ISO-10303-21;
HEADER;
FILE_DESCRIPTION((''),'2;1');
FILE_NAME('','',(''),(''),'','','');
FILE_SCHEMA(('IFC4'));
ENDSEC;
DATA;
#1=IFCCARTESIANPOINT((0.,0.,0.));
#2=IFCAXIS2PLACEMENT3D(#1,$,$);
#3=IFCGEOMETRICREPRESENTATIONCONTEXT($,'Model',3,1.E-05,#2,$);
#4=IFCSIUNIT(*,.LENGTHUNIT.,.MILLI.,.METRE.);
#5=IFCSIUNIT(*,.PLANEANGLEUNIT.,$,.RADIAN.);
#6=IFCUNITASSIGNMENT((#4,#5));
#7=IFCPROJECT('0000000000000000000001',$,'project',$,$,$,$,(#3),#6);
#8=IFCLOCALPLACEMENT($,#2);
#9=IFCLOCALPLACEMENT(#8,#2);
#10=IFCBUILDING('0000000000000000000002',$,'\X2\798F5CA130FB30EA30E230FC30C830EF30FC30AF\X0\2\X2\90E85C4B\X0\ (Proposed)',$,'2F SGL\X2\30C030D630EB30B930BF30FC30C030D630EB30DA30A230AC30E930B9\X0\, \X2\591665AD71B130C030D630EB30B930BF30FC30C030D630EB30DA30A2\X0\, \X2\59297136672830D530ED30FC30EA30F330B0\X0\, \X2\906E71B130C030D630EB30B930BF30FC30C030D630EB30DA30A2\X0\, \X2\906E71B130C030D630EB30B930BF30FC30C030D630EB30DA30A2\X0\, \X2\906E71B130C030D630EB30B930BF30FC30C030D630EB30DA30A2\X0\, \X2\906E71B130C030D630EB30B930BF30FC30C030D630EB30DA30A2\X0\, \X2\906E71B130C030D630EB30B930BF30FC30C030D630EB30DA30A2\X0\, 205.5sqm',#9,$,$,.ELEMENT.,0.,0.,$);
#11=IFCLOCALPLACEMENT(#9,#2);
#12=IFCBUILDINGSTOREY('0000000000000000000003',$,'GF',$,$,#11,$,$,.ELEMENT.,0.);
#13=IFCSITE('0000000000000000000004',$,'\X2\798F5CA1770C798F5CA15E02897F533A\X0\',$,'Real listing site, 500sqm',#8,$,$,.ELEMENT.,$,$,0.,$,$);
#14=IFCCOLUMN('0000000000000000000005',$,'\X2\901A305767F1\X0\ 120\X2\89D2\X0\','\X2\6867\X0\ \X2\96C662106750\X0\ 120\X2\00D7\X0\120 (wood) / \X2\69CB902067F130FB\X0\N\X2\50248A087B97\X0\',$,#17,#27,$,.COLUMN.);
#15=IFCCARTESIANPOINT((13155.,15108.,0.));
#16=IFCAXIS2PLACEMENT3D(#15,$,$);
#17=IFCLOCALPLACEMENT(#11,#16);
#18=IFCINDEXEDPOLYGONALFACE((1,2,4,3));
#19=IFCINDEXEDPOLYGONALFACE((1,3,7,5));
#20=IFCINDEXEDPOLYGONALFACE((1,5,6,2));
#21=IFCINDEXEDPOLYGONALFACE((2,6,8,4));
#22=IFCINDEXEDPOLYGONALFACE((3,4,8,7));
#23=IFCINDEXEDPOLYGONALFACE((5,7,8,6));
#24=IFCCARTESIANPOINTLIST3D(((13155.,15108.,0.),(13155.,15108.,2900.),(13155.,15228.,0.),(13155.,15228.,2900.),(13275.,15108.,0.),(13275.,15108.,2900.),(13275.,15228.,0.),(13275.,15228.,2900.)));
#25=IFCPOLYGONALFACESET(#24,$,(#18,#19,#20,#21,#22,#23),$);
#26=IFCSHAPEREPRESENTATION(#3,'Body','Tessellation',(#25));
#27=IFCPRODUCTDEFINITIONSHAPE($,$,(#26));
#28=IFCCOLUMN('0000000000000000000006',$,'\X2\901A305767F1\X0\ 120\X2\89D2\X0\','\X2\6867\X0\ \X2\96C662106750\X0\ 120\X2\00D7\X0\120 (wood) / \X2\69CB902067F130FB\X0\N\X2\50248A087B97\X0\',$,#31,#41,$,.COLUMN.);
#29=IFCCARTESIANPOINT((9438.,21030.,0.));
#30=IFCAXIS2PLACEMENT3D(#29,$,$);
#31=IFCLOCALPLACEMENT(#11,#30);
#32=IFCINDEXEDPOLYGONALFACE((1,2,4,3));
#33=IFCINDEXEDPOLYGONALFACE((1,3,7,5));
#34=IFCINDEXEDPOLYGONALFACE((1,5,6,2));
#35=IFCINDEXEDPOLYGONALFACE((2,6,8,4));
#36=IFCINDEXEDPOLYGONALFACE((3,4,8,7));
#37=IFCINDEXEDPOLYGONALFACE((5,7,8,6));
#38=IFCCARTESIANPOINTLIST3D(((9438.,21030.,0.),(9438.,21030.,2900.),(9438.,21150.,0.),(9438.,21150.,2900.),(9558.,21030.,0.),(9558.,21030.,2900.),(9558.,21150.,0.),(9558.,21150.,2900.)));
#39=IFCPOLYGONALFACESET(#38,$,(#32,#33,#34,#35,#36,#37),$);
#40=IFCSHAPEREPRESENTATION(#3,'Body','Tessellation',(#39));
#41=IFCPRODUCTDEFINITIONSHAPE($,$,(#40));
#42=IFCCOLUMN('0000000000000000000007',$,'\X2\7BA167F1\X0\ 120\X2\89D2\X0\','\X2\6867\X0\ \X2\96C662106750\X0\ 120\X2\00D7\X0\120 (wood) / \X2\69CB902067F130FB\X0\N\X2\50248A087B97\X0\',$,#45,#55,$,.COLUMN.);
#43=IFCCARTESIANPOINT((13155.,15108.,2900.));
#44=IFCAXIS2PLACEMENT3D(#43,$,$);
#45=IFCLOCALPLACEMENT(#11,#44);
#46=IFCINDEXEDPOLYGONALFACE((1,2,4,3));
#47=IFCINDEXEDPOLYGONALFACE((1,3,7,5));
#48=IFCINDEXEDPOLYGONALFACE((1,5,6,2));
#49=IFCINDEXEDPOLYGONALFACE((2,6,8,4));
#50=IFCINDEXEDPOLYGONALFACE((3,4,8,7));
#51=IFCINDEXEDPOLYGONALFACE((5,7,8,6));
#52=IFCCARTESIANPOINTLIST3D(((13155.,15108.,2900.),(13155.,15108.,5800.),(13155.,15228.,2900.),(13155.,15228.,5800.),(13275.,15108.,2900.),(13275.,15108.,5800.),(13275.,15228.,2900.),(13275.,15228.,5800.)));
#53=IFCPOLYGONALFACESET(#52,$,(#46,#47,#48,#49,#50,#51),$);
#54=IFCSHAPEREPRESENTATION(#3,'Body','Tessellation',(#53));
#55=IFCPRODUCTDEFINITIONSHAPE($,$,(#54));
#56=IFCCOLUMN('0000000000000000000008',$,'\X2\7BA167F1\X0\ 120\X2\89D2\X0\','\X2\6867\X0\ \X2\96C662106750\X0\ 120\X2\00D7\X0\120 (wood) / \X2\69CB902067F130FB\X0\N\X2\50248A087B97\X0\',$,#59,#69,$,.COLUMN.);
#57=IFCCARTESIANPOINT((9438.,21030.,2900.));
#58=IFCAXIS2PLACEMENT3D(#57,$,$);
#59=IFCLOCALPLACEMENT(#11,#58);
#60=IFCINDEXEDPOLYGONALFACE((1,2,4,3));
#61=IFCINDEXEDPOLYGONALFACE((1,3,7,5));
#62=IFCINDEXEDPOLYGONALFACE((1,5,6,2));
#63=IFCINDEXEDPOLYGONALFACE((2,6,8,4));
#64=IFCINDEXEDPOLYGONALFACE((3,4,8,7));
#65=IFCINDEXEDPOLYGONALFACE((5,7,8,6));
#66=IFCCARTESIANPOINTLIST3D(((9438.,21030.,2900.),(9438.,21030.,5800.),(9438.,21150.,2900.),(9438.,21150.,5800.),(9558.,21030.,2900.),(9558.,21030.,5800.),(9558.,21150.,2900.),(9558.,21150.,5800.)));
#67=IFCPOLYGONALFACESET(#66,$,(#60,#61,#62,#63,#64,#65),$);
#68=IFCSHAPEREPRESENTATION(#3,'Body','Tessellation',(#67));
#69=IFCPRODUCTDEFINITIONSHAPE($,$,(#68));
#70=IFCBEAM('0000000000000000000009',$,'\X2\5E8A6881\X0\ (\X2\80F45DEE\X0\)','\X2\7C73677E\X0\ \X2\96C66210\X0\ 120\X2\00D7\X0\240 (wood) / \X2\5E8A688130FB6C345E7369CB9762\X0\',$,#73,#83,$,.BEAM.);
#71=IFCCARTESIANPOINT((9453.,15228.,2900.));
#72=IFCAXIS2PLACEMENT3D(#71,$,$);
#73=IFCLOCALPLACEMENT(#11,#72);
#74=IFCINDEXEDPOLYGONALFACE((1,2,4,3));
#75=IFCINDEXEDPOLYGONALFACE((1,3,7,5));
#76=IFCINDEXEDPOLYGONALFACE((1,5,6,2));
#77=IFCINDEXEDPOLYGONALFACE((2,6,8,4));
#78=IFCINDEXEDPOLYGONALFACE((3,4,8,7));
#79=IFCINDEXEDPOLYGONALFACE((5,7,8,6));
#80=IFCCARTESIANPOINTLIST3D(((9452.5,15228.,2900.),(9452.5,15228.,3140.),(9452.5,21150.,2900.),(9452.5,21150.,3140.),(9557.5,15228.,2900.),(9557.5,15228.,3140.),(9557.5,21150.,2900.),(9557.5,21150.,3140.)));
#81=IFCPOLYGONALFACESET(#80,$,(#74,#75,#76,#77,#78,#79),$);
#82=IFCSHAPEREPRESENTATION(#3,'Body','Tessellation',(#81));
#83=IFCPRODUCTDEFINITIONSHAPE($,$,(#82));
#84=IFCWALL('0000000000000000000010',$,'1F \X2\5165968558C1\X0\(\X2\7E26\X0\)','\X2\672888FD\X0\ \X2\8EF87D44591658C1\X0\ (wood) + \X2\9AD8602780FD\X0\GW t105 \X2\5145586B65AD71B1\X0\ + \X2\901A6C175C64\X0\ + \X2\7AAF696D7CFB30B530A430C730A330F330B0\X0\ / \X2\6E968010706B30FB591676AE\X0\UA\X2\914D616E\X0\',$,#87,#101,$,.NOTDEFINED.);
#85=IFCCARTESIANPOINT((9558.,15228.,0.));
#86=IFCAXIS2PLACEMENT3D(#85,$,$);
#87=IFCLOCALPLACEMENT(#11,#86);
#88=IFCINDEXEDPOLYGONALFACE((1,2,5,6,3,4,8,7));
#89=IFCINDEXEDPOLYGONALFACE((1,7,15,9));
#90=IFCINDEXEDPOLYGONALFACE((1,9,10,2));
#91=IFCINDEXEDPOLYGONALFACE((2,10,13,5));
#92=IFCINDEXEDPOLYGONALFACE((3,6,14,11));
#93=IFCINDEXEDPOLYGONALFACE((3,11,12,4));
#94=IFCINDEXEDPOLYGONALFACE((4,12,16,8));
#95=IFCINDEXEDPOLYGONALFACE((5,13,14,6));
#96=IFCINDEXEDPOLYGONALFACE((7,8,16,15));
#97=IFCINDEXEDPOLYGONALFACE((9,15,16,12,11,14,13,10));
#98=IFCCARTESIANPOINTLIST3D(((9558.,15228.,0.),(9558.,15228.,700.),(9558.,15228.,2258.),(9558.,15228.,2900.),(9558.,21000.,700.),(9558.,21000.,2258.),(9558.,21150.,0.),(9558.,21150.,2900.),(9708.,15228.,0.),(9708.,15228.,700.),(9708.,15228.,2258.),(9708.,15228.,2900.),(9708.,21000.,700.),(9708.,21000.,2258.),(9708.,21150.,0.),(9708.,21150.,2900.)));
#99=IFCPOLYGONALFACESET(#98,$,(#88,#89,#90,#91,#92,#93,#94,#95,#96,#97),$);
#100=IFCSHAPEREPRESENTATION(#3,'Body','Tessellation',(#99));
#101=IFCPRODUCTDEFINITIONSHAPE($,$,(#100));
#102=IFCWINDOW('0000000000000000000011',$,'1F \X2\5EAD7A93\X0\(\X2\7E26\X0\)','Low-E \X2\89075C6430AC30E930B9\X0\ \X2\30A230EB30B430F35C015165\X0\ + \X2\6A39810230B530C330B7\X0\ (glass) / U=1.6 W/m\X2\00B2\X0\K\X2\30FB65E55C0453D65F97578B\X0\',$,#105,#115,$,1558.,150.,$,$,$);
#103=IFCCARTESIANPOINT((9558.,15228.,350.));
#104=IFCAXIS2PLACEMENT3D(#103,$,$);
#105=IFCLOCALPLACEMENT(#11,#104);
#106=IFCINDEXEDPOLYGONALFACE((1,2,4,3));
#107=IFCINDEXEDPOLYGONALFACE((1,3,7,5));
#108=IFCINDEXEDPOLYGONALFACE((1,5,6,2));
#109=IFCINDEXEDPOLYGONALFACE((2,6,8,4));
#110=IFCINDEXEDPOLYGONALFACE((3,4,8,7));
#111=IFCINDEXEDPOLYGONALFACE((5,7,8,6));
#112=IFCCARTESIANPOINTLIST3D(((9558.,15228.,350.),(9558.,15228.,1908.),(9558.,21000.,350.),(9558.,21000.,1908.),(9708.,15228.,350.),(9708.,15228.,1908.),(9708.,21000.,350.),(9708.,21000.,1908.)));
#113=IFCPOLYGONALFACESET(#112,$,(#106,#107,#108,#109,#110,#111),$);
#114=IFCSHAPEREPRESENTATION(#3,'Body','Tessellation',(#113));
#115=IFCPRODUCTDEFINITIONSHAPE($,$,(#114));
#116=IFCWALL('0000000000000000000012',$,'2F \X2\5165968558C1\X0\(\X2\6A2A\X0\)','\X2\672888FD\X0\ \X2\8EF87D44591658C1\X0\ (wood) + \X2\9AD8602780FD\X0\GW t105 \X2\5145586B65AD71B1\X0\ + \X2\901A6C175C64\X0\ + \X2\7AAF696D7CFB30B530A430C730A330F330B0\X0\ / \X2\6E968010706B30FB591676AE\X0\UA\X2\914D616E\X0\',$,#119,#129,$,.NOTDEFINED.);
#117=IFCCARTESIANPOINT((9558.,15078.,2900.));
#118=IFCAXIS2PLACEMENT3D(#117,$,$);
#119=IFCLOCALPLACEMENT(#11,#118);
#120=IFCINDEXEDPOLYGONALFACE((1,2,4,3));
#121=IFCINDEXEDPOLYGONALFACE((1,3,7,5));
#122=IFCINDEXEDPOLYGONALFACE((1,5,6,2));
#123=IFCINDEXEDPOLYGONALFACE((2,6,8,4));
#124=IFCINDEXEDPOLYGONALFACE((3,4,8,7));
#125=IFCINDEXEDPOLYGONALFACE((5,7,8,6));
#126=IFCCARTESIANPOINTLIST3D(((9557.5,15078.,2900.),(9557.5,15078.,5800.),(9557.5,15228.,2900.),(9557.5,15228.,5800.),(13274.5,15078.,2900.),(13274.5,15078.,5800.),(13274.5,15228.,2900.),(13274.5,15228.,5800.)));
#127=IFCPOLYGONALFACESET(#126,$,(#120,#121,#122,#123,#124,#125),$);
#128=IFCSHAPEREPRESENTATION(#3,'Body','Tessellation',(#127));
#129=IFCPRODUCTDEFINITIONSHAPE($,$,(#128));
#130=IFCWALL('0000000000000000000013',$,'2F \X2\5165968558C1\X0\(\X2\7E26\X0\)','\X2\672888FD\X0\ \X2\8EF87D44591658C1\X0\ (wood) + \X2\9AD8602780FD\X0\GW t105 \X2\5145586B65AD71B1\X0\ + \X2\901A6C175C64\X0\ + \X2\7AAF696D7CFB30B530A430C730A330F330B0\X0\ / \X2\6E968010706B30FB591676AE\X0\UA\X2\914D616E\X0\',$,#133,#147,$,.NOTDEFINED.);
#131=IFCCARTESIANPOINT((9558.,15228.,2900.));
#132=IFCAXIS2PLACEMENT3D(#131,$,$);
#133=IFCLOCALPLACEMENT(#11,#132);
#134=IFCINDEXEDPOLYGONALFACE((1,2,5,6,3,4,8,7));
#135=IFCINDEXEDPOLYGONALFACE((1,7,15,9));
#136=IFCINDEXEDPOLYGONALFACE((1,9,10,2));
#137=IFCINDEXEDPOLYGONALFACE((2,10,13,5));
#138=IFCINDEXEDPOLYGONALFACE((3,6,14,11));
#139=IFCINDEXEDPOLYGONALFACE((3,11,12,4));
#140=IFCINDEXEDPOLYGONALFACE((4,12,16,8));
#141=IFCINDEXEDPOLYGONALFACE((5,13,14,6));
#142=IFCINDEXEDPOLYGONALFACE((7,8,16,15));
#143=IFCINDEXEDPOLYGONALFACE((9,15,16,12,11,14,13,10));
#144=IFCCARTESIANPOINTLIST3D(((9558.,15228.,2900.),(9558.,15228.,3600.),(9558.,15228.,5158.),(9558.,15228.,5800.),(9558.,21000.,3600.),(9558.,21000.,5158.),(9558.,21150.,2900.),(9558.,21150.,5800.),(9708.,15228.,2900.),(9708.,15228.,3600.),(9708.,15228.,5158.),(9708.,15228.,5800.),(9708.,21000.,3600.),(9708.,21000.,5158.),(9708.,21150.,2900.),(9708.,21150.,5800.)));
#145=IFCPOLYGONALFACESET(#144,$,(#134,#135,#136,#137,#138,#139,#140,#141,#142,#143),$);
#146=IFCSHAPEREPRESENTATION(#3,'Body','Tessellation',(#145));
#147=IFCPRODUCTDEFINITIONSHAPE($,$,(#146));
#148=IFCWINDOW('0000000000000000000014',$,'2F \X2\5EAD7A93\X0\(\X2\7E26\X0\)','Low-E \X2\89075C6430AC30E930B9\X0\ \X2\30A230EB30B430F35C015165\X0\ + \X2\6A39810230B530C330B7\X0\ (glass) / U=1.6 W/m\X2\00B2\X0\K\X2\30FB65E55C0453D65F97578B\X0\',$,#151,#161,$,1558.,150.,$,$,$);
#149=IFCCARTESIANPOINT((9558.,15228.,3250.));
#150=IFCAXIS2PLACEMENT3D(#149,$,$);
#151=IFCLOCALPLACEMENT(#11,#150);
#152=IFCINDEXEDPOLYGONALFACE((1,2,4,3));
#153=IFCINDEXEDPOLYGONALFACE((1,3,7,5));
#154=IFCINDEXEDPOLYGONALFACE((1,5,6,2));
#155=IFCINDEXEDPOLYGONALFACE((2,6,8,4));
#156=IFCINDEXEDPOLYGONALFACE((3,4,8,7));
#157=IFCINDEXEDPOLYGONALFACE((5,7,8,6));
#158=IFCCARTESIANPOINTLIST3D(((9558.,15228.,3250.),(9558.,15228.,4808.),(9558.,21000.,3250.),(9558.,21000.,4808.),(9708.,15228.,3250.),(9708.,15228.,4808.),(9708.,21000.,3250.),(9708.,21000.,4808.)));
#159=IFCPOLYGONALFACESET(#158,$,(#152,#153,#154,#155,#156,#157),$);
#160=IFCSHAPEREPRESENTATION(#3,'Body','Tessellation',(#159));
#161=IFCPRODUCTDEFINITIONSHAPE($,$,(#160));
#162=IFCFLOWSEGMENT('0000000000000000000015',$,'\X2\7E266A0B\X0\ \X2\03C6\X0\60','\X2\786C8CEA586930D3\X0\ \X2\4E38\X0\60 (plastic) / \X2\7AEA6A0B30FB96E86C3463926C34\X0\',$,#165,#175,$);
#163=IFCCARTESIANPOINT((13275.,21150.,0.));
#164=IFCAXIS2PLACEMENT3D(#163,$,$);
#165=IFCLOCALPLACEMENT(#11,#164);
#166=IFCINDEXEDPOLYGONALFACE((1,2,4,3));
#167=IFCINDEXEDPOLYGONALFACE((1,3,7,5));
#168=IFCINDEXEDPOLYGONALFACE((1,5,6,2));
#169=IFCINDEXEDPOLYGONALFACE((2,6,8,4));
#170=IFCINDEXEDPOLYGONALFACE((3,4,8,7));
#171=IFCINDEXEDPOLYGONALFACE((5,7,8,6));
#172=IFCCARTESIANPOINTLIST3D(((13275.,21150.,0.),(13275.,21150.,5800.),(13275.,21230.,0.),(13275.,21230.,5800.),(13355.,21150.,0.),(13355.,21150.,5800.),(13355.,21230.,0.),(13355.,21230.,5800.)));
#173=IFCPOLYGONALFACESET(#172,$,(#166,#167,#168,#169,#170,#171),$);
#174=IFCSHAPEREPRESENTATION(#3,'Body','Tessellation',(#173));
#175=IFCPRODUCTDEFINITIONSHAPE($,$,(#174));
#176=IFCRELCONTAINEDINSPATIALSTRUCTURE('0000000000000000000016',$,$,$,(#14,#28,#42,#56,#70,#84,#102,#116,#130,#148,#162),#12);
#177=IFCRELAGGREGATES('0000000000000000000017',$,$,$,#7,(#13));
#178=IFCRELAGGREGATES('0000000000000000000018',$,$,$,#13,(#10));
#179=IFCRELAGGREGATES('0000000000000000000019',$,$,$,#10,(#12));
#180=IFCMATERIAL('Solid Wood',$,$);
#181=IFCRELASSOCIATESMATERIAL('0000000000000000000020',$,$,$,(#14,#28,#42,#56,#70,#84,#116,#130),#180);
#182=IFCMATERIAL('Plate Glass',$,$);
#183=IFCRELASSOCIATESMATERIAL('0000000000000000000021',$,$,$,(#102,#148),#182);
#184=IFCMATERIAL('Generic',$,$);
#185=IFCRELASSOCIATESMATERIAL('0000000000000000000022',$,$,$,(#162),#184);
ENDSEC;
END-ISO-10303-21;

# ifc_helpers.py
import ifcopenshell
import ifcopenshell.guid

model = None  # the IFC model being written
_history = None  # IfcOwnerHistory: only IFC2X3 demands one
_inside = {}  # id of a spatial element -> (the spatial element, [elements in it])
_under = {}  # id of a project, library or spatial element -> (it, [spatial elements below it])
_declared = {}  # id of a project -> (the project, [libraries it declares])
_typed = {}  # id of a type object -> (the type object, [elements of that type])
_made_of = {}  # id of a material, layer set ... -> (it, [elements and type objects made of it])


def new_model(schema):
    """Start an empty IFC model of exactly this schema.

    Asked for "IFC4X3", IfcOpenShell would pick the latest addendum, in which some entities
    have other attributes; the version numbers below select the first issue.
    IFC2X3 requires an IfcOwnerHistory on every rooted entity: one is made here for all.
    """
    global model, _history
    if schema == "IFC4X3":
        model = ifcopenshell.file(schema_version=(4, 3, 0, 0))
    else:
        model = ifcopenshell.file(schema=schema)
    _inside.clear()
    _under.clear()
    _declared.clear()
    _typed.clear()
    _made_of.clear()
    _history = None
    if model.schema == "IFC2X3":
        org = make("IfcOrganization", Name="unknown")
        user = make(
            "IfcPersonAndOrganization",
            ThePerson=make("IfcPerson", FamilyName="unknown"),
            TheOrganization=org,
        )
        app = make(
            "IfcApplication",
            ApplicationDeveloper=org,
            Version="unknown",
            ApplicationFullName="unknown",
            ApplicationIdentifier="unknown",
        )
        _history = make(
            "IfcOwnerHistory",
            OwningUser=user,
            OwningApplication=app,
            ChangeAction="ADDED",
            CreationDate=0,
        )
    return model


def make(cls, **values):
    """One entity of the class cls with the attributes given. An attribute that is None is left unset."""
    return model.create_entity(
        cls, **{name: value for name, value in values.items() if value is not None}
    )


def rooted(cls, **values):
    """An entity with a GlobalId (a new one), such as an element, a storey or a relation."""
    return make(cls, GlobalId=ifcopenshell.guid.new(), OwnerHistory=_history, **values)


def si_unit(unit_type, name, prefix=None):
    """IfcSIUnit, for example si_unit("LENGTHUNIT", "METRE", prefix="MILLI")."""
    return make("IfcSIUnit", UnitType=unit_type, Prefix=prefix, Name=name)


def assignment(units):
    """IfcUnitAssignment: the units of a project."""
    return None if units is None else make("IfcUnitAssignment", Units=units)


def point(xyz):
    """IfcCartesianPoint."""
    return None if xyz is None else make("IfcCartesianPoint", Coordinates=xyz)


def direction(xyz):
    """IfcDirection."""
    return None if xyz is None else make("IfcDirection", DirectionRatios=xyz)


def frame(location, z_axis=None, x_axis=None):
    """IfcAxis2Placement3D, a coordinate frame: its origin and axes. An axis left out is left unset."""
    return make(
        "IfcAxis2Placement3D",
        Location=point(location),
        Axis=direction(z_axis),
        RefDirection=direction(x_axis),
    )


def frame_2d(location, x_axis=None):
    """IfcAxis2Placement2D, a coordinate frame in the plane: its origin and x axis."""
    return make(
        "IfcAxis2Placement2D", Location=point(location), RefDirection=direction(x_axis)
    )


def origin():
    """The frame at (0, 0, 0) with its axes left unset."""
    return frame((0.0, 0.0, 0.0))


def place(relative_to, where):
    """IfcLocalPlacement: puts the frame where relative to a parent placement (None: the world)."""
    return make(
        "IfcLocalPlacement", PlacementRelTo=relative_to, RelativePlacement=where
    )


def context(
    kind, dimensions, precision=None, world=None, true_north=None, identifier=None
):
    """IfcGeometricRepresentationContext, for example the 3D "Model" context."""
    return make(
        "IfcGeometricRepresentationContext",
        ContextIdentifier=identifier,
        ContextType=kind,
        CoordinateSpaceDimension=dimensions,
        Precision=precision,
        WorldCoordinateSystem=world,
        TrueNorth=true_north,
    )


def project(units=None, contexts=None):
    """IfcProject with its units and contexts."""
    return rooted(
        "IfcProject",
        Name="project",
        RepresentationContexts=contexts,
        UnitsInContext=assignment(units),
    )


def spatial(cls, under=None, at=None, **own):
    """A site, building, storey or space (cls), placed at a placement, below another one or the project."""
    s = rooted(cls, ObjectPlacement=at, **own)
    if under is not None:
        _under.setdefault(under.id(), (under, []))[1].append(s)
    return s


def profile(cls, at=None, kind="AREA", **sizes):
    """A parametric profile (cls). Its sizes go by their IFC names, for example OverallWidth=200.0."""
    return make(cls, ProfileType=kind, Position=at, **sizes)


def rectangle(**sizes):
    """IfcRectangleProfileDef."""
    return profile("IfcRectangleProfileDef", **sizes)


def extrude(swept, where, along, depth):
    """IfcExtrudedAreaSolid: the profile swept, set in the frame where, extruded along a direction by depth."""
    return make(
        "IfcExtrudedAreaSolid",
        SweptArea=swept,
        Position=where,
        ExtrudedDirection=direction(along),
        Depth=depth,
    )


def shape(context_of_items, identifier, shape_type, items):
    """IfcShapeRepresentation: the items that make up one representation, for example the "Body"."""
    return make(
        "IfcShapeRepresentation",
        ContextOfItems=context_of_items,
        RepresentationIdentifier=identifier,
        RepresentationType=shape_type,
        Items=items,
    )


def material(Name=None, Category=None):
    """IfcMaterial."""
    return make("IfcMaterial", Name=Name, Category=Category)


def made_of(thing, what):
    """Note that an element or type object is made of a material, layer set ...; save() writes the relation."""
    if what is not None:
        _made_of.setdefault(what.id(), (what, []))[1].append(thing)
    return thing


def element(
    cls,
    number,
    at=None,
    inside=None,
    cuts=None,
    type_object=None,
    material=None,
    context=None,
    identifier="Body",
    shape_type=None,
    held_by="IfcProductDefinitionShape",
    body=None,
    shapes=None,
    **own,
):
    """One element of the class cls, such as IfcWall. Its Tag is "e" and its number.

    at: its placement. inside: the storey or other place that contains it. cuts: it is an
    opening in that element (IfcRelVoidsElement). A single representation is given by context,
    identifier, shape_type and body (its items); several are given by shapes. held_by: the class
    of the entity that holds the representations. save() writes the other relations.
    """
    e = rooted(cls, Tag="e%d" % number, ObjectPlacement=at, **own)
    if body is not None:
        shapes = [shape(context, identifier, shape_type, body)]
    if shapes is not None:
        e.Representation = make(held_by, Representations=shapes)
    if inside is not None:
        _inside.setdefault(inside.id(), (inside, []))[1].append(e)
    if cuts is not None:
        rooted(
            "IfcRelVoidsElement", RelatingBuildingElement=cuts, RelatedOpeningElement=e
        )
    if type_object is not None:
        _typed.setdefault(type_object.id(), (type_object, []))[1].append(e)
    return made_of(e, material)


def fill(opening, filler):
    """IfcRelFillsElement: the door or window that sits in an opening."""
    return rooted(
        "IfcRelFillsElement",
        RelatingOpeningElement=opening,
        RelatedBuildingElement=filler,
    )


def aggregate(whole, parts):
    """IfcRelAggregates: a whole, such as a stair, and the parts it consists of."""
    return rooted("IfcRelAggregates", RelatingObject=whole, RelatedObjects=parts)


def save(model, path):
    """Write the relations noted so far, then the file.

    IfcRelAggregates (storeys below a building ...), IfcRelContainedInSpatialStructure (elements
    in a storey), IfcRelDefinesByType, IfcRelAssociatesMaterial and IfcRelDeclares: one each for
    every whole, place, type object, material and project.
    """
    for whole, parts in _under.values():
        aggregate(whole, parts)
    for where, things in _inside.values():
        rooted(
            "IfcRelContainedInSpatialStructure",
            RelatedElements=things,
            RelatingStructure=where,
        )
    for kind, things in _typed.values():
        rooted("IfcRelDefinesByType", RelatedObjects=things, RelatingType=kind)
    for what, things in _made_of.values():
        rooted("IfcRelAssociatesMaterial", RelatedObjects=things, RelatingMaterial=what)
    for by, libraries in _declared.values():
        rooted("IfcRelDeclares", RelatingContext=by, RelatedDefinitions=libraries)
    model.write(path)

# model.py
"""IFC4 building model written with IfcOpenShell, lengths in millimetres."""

from ifc_helpers import new_model, si_unit, frame, frame_2d, origin, place, context, project, spatial, rectangle, extrude, material, element, fill, save


model = new_model("IFC4")

# Units and contexts
model_context = context("Model", 3, precision=1e-05, world=origin())
ifc_project = project(units=[si_unit("LENGTHUNIT", "METRE", prefix="MILLI"), si_unit("PLANEANGLEUNIT", "RADIAN")], contexts=[model_context])

# Site, building, storey
site_placement = place(None, origin())
site = spatial("IfcSite", under=ifc_project, at=site_placement, Name="福岡県福岡市西区", ObjectType="Real listing site, 500sqm", CompositionType="ELEMENT", RefElevation=0.0)
building_placement = place(site_placement, origin())
building = spatial("IfcBuilding", under=site, at=building_placement, Name="福岡・リモートワーク2部屋 (Proposed)", ObjectType="2F SGLダブルスターダブルペアガラス, 外断熱ダブルスターダブルペア, 天然木フローリング, 遮熱ダブルスターダブルペア, 遮熱ダブルスターダブルペア, 遮熱ダブルスターダブルペア, 遮熱ダブルスターダブルペア, 遮熱ダブルスターダブルペア, 205.5sqm", CompositionType="ELEMENT", ElevationOfRefHeight=0.0, ElevationOfTerrain=0.0)
storey_placement = place(building_placement, origin())
storey = spatial("IfcBuildingStorey", under=building, at=storey_placement, Name="GF", CompositionType="ELEMENT", Elevation=0.0)

# Columns
ifc_material_1 = material(Name="Solid Wood")
column_1_placement = place(storey_placement, frame((13155.0, 15108.0, 0.0)))
element("IfcColumn", 1, at=column_1_placement, inside=storey, material=ifc_material_1, Name="通し柱 120角", Description="桧 集成材 120×120 (wood) / 構造柱・N値計算", PredefinedType="COLUMN", context=model_context, shape_type="SweptSolid", body=[
    extrude(rectangle(XDim=120.0, YDim=120.0, at=frame_2d((60.0, 60.0))), frame((13155.0, 15108.0, 0.0)), (0.0, 0.0, 1.0), 2900.0),
])
column_2_placement = place(storey_placement, frame((9438.0, 21030.0, 0.0)))
element("IfcColumn", 2, at=column_2_placement, inside=storey, material=ifc_material_1, Name="通し柱 120角", Description="桧 集成材 120×120 (wood) / 構造柱・N値計算", PredefinedType="COLUMN", context=model_context, shape_type="SweptSolid", body=[
    extrude(rectangle(XDim=120.0, YDim=120.0, at=frame_2d((60.0, 60.0))), frame((9438.0, 21030.0, 0.0)), (0.0, 0.0, 1.0), 2900.0),
])
column_3_placement = place(storey_placement, frame((13155.0, 15108.0, 2900.0)))
element("IfcColumn", 3, at=column_3_placement, inside=storey, material=ifc_material_1, Name="管柱 120角", Description="桧 集成材 120×120 (wood) / 構造柱・N値計算", PredefinedType="COLUMN", context=model_context, shape_type="SweptSolid", body=[
    extrude(rectangle(XDim=120.0, YDim=120.0, at=frame_2d((60.0, 60.0))), frame((13155.0, 15108.0, 2900.0)), (0.0, 0.0, 1.0), 2900.0),
])
column_4_placement = place(storey_placement, frame((9438.0, 21030.0, 2900.0)))
element("IfcColumn", 4, at=column_4_placement, inside=storey, material=ifc_material_1, Name="管柱 120角", Description="桧 集成材 120×120 (wood) / 構造柱・N値計算", PredefinedType="COLUMN", context=model_context, shape_type="SweptSolid", body=[
    extrude(rectangle(XDim=120.0, YDim=120.0, at=frame_2d((60.0, 60.0))), frame((9438.0, 21030.0, 2900.0)), (0.0, 0.0, 1.0), 2900.0),
])

# Beam
beam_1_placement = place(storey_placement, frame((9453.0, 15228.0, 2900.0)))
element("IfcBeam", 5, at=beam_1_placement, inside=storey, material=ifc_material_1, Name="床梁 (胴差)", Description="米松 集成 120×240 (wood) / 床梁・水平構面", PredefinedType="BEAM", context=model_context, shape_type="SweptSolid", body=[
    extrude(rectangle(XDim=105.0, YDim=5922.0, at=frame_2d((52.0, 2961.0))), frame((9453.0, 15228.0, 2900.0)), (0.0, 0.0, 1.0), 240.0),
])

# Wall, opening, window
wall_1_placement = place(storey_placement, frame((9558.0, 15228.0, 0.0)))
wall_1 = element("IfcWall", 6, at=wall_1_placement, inside=storey, material=ifc_material_1, Name="1F 入隅壁(縦)", Description="木製 軸組外壁 (wood) + 高性能GW t105 充填断熱 + 通気層 + 窯業系サイディング / 準耐火・外皮UA配慮", PredefinedType="NOTDEFINED", context=model_context, shape_type="SweptSolid", body=[
    extrude(rectangle(XDim=150.0, YDim=5922.0, at=frame_2d((75.0, 2961.0))), frame((9558.0, 15228.0, 0.0)), (0.0, 0.0, 1.0), 2900.0),
])
opening_1_placement = place(storey_placement, frame((9558.0, 15228.0, 350.0)))
opening_1 = element("IfcOpeningElement", 7, at=opening_1_placement, cuts=wall_1, PredefinedType="NOTDEFINED", context=model_context, shape_type="SweptSolid", body=[
    extrude(rectangle(XDim=150.0, YDim=5772.0, at=frame_2d((75.0, 2886.0))), frame((9558.0, 15228.0, 350.0)), (0.0, 0.0, 1.0), 1558.0),
])
ifc_material_2 = material(Name="Plate Glass")
window_1_placement = place(storey_placement, frame((9558.0, 15228.0, 350.0)))
window_1 = element("IfcWindow", 8, at=window_1_placement, inside=storey, material=ifc_material_2, Name="1F 庭窓(縦)", Description="Low-E 複層ガラス アルゴン封入 + 樹脂サッシ (glass) / U=1.6 W/m²K・日射取得型", OverallHeight=1558.0, OverallWidth=150.0, context=model_context, shape_type="SweptSolid", body=[
    extrude(rectangle(XDim=150.0, YDim=5772.0, at=frame_2d((75.0, 2886.0))), frame((9558.0, 15228.0, 350.0)), (0.0, 0.0, 1.0), 1558.0),
])
fill(opening_1, window_1)

# Wall
wall_2_placement = place(storey_placement, frame((9558.0, 15078.0, 2900.0)))
element("IfcWall", 9, at=wall_2_placement, inside=storey, material=ifc_material_1, Name="2F 入隅壁(横)", Description="木製 軸組外壁 (wood) + 高性能GW t105 充填断熱 + 通気層 + 窯業系サイディング / 準耐火・外皮UA配慮", PredefinedType="NOTDEFINED", context=model_context, shape_type="SweptSolid", body=[
    extrude(rectangle(XDim=3717.0, YDim=150.0, at=frame_2d((1858.0, 75.0))), frame((9558.0, 15078.0, 2900.0)), (0.0, 0.0, 1.0), 2900.0),
])

# Wall, opening, window
wall_3_placement = place(storey_placement, frame((9558.0, 15228.0, 2900.0)))
wall_3 = element("IfcWall", 10, at=wall_3_placement, inside=storey, material=ifc_material_1, Name="2F 入隅壁(縦)", Description="木製 軸組外壁 (wood) + 高性能GW t105 充填断熱 + 通気層 + 窯業系サイディング / 準耐火・外皮UA配慮", PredefinedType="NOTDEFINED", context=model_context, shape_type="SweptSolid", body=[
    extrude(rectangle(XDim=150.0, YDim=5922.0, at=frame_2d((75.0, 2961.0))), frame((9558.0, 15228.0, 2900.0)), (0.0, 0.0, 1.0), 2900.0),
])
opening_2_placement = place(storey_placement, frame((9558.0, 15228.0, 3250.0)))
opening_2 = element("IfcOpeningElement", 11, at=opening_2_placement, cuts=wall_3, PredefinedType="NOTDEFINED", context=model_context, shape_type="SweptSolid", body=[
    extrude(rectangle(XDim=150.0, YDim=5772.0, at=frame_2d((75.0, 2886.0))), frame((9558.0, 15228.0, 3250.0)), (0.0, 0.0, 1.0), 1558.0),
])
window_2_placement = place(storey_placement, frame((9558.0, 15228.0, 3250.0)))
window_2 = element("IfcWindow", 12, at=window_2_placement, inside=storey, material=ifc_material_2, Name="2F 庭窓(縦)", Description="Low-E 複層ガラス アルゴン封入 + 樹脂サッシ (glass) / U=1.6 W/m²K・日射取得型", OverallHeight=1558.0, OverallWidth=150.0, context=model_context, shape_type="SweptSolid", body=[
    extrude(rectangle(XDim=150.0, YDim=5772.0, at=frame_2d((75.0, 2886.0))), frame((9558.0, 15228.0, 3250.0)), (0.0, 0.0, 1.0), 1558.0),
])
fill(opening_2, window_2)

# Flow segment
ifc_material_3 = material(Name="Generic")
flow_segment_placement = place(storey_placement, frame((13275.0, 21150.0, 0.0)))
element("IfcFlowSegment", 13, at=flow_segment_placement, inside=storey, material=ifc_material_3, Name="縦樋 φ60", Description="硬質塩ビ 丸60 (plastic) / 竪樋・雨水排水", context=model_context, shape_type="SweptSolid", body=[
    extrude(rectangle(XDim=80.0, YDim=80.0, at=frame_2d((40.0, 40.0))), frame((13275.0, 21150.0, 0.0)), (0.0, 0.0, 1.0), 5800.0),
])

save(model, "model.ifc")
